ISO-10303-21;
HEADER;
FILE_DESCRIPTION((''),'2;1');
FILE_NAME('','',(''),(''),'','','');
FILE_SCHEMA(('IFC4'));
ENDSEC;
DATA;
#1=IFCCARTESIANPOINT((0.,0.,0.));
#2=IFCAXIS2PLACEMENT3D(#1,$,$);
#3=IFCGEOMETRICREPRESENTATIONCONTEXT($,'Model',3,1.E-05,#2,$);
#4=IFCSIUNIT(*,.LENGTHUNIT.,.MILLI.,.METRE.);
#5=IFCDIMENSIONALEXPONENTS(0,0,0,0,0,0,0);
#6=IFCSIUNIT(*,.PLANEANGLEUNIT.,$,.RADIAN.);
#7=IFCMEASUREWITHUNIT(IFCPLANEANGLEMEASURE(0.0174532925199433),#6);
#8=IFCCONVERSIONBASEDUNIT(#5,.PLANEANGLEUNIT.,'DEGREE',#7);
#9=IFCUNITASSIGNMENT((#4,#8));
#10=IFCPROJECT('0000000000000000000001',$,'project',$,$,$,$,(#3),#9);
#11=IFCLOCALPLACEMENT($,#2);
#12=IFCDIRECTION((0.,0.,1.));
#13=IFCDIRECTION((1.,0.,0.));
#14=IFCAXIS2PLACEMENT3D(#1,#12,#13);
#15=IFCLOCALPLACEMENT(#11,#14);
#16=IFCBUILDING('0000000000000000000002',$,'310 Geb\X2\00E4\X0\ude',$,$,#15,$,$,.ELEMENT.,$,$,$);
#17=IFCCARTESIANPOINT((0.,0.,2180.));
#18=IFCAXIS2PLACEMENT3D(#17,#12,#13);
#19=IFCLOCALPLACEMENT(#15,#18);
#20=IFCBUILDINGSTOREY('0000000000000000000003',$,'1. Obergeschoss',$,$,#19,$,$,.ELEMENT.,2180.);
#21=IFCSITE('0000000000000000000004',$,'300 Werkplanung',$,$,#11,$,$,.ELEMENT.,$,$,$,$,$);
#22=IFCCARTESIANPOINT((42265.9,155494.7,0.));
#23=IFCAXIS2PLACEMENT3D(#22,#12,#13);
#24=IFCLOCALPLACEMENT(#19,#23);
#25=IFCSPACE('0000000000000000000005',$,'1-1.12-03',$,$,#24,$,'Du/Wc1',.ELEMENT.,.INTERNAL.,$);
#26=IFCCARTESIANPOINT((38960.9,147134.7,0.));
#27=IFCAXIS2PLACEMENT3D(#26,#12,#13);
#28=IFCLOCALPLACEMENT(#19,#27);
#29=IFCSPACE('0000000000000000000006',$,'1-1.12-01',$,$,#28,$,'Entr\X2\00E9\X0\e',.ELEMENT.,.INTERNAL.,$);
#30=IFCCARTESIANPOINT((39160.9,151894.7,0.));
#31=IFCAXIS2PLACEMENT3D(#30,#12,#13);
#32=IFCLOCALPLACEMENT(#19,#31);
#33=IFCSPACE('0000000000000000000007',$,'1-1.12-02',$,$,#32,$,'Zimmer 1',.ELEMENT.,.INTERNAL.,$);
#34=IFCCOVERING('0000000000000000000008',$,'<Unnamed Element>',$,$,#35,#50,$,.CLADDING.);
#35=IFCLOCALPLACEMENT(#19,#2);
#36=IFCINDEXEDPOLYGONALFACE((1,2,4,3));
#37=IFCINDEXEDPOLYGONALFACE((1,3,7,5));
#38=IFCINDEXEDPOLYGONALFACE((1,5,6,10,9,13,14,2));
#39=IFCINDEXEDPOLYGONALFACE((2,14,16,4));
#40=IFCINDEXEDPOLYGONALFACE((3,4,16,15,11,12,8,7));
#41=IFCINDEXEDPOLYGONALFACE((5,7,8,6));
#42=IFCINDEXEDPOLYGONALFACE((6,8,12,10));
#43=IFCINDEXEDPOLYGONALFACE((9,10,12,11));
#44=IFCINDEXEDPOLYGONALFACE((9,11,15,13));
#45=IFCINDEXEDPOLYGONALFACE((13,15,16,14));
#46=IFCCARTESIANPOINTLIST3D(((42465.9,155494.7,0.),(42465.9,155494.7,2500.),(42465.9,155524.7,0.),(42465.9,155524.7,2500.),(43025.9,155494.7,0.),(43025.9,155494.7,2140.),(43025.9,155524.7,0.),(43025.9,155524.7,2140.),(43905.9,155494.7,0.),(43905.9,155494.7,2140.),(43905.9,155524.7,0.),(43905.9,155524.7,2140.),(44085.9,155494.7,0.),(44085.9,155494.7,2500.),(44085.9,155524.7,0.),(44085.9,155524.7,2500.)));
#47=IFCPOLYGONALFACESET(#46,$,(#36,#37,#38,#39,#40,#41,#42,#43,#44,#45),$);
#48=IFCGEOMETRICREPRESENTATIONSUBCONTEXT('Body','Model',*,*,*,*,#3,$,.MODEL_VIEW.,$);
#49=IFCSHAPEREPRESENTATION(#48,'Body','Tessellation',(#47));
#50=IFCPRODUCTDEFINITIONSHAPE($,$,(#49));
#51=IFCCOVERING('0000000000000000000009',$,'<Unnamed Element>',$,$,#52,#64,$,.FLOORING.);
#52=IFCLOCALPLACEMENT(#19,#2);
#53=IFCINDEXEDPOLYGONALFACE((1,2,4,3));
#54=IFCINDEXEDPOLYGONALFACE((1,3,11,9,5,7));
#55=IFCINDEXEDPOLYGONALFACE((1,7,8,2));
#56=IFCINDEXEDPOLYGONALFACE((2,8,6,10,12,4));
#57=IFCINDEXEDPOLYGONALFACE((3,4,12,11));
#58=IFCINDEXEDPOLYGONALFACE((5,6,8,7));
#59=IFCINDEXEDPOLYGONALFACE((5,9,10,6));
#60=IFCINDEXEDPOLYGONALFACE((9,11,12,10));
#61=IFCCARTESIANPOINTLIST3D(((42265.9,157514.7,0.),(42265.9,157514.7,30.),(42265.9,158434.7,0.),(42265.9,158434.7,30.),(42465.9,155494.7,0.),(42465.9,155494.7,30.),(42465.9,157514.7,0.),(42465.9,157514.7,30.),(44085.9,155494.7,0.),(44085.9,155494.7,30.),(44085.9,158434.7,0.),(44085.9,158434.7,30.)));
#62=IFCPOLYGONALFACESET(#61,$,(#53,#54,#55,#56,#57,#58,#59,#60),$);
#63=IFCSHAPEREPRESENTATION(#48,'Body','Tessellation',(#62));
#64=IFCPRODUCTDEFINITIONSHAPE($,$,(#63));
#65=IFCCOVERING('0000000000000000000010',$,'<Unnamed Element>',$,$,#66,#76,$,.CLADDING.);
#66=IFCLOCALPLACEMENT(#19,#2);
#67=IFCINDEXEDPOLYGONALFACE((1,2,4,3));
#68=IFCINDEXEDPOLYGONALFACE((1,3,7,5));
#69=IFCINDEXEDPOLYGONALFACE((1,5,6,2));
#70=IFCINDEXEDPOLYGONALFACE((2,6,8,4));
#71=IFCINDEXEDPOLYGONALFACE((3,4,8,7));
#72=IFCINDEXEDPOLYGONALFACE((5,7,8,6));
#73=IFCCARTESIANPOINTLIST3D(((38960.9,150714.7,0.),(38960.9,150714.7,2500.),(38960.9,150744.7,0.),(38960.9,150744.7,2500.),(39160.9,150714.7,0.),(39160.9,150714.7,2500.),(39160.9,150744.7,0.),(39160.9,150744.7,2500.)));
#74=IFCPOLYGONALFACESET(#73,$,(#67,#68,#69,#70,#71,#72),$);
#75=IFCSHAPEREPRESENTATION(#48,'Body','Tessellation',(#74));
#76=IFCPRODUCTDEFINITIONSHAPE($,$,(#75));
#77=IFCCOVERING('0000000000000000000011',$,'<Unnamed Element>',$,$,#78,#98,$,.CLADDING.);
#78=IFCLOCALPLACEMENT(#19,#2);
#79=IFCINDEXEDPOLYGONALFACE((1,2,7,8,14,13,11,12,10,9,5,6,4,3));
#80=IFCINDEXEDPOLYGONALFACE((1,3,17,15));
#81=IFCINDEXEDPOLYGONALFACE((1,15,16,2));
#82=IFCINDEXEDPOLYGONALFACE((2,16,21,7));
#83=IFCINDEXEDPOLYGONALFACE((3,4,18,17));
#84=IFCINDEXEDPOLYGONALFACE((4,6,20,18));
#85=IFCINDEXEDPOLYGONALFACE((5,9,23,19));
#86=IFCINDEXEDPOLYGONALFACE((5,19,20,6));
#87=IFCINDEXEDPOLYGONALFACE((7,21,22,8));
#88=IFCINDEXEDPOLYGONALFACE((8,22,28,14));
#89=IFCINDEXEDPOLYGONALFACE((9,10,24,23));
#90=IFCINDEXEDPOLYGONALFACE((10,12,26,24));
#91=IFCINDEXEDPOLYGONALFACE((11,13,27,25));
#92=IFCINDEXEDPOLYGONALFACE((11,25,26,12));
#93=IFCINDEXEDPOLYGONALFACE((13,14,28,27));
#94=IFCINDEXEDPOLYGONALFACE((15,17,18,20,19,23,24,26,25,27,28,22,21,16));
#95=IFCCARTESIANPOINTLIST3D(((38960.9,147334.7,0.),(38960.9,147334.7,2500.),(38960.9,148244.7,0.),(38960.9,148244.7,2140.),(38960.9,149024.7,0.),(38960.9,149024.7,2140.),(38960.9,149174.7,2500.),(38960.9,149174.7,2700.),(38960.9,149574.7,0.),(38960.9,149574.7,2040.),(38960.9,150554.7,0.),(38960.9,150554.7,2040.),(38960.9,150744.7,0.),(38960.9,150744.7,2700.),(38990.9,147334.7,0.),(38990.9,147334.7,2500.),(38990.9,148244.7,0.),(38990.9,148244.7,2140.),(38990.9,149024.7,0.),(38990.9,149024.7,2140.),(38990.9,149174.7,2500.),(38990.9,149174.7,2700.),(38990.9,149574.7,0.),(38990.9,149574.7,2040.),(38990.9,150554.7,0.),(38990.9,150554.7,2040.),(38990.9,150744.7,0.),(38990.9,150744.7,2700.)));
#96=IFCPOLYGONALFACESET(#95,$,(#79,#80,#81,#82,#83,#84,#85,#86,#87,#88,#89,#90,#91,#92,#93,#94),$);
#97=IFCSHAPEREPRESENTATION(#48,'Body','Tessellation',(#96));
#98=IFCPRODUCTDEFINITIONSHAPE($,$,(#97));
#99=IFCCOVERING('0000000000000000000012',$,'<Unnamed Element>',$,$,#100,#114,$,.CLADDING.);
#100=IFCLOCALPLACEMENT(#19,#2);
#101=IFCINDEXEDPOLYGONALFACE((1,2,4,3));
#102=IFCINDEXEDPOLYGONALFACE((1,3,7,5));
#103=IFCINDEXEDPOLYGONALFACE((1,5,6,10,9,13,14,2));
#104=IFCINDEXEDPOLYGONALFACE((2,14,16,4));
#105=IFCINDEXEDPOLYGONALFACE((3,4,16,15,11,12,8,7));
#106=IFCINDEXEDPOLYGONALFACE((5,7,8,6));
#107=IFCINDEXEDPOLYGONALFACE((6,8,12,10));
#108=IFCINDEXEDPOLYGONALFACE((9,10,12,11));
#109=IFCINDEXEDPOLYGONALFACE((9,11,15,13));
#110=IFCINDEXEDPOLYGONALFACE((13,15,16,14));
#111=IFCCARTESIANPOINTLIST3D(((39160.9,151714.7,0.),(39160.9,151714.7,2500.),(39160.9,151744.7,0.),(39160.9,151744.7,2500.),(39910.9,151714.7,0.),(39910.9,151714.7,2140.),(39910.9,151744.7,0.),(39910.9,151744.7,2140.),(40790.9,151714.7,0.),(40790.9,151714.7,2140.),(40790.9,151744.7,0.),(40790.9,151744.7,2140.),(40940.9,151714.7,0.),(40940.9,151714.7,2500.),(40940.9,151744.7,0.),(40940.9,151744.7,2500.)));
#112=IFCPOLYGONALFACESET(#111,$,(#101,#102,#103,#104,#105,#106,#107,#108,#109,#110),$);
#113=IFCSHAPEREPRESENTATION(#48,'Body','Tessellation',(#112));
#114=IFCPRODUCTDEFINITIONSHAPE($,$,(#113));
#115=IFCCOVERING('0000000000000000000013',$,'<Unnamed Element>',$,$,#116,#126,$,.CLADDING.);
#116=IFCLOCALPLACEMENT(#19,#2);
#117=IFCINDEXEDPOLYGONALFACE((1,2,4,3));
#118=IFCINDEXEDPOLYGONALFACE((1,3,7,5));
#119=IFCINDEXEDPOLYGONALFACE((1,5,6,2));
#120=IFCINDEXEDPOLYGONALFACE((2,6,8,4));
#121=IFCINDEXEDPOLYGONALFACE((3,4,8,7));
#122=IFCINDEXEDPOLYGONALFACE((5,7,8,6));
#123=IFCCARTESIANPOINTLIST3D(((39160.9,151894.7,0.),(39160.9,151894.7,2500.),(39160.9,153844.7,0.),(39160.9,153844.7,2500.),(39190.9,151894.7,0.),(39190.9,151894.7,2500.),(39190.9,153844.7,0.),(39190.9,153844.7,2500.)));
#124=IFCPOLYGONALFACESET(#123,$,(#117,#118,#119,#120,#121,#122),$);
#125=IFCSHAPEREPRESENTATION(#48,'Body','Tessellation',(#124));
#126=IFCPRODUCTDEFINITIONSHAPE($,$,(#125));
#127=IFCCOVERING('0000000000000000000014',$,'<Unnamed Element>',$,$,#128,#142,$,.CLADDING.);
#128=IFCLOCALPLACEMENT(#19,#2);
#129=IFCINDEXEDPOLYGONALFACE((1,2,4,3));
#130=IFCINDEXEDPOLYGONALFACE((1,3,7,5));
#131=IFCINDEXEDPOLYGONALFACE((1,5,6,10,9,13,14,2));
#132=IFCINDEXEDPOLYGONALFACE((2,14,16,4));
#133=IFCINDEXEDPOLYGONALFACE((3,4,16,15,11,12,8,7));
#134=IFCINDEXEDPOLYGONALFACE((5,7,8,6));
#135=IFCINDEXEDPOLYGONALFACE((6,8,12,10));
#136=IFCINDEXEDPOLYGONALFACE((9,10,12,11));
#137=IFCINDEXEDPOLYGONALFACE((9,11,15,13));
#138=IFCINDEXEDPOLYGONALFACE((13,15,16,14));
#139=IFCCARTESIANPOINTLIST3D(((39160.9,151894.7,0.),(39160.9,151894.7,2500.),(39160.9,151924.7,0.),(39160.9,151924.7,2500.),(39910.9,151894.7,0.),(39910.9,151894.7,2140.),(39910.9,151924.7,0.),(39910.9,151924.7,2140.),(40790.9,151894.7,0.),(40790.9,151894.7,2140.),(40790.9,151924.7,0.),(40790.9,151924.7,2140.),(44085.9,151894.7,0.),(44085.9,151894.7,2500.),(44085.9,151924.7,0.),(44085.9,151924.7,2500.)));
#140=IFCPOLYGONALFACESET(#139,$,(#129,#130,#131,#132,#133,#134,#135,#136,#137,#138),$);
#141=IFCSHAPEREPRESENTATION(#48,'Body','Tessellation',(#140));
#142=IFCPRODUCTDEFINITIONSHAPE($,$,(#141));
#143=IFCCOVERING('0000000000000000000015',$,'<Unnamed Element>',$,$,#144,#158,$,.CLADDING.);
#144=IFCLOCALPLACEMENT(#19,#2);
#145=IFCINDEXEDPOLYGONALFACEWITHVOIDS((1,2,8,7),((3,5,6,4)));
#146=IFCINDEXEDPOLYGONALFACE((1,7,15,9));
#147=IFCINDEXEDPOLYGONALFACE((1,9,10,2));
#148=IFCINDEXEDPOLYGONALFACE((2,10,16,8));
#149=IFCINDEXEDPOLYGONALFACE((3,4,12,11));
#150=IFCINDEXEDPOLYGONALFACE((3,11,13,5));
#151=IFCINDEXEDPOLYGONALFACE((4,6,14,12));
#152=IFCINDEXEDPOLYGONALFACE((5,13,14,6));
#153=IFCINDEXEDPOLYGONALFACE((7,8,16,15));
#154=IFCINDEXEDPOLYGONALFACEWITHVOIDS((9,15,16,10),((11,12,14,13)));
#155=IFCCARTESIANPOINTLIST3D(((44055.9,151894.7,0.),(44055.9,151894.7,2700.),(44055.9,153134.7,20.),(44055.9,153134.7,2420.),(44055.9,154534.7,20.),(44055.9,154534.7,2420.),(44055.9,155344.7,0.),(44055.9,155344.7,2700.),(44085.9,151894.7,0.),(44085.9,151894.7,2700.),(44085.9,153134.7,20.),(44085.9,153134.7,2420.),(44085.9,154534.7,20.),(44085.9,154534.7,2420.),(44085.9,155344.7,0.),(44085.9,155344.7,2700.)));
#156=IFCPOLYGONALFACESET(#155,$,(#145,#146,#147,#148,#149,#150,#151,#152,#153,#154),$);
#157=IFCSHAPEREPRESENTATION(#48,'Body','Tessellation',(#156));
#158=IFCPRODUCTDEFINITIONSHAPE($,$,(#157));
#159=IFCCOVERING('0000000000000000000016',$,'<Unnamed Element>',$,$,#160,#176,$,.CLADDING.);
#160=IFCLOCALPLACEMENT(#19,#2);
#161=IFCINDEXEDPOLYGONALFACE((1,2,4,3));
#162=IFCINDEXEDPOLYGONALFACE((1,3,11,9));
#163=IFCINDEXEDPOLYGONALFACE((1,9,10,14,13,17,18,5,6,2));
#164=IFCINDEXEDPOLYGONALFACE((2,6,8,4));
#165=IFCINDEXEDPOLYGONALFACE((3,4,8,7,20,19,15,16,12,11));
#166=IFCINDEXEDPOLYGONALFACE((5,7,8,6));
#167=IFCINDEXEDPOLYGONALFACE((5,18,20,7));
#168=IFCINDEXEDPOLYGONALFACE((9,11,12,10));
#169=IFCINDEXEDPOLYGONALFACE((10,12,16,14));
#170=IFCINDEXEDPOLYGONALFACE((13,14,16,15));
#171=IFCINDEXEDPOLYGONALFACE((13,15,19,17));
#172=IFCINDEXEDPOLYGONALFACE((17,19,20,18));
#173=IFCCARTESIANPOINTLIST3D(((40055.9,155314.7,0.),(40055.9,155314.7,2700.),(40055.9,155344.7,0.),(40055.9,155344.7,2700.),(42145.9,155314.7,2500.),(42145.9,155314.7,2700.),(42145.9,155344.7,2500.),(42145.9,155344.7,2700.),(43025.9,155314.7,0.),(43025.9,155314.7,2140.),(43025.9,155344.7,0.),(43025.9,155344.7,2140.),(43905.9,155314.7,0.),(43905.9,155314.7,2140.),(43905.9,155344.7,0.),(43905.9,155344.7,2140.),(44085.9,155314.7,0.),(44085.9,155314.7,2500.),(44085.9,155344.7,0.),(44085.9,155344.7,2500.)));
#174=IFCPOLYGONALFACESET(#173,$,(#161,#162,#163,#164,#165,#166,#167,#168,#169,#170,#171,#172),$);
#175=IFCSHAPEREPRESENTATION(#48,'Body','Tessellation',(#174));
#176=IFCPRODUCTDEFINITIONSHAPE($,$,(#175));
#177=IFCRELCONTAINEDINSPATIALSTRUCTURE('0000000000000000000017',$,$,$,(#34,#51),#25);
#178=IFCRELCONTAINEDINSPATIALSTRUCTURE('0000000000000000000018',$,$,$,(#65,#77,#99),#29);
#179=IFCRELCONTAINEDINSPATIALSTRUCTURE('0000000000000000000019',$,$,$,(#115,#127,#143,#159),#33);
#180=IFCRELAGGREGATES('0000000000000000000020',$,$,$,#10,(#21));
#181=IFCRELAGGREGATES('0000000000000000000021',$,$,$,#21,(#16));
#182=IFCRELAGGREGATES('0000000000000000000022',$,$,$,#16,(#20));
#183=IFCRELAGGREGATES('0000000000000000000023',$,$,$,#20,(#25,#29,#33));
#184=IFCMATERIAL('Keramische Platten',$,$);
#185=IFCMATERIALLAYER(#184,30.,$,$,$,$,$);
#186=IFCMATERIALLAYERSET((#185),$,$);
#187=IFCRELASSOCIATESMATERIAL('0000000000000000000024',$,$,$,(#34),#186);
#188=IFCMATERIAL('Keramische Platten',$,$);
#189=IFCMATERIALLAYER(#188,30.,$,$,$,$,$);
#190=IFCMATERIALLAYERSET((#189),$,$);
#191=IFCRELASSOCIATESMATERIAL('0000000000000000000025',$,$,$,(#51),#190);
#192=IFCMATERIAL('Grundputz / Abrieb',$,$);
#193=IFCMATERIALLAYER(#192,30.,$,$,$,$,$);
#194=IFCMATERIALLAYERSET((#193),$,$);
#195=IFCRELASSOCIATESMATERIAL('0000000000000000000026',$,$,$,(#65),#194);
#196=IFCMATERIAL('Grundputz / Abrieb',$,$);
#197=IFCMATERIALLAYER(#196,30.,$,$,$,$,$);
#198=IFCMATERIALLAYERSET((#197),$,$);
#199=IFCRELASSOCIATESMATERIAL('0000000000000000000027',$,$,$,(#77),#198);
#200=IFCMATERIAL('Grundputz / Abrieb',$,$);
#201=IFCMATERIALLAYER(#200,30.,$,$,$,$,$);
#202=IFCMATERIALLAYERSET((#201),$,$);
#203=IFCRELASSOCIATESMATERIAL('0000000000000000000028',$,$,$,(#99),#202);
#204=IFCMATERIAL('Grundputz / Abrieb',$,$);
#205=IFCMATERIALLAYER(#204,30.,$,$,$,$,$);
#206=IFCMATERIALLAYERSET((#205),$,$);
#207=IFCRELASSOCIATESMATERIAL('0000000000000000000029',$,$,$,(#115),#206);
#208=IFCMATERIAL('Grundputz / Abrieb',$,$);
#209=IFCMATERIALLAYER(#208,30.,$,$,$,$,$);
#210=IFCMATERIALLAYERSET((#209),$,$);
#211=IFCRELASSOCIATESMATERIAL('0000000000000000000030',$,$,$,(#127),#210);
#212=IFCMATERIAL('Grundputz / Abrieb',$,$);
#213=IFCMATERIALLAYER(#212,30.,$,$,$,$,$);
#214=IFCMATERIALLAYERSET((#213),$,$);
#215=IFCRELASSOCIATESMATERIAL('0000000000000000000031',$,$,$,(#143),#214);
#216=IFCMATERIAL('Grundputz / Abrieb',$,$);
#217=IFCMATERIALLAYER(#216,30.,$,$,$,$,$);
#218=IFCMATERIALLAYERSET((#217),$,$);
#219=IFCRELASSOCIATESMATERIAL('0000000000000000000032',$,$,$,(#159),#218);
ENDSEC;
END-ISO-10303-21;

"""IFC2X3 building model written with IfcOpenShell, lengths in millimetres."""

from ifc_helpers import new_model, entity, si_unit, converted_unit, frame, frame_2d, origin, origin_with_axes, place, context, subcontext, project, spatial, polyline, rectangle, outline, extrude, material, layer, layer_set, layer_usage, element, save


model = new_model("IFC2X3")

# Units and contexts
model_context = context("Model", 3, precision=1e-05, world=origin())
body_context = subcontext(model_context, "Body", "Model", "MODEL_VIEW")
ifc_project = project(units=[si_unit("LENGTHUNIT", "METRE", prefix="MILLI"), converted_unit("PLANEANGLEUNIT", "DEGREE", entity("IfcPlaneAngleMeasure", 0.0174532925199433), si_unit("PLANEANGLEUNIT", "RADIAN"), dimensions=[0, 0, 0, 0, 0, 0, 0])], contexts=[model_context])

# Site, building, storey
site_placement = place(None, origin())
site = spatial("IfcSite", under=ifc_project, at=site_placement, Name="300 Werkplanung", CompositionType="ELEMENT")
building_placement = place(site_placement, origin_with_axes())
building = spatial("IfcBuilding", under=site, at=building_placement, Name="310 Gebäude", CompositionType="ELEMENT")
storey_placement = place(building_placement, frame((0.0, 0.0, 2180.0), z_axis=(0.0, 0.0, 1.0), x_axis=(1.0, 0.0, 0.0)))
storey = spatial("IfcBuildingStorey", under=building, at=storey_placement, Name="1. Obergeschoss", CompositionType="ELEMENT", Elevation=2180.0)

# Shared definitions
space_1_placement = place(storey_placement, frame((42265.9, 155494.7, 0.0), z_axis=(0.0, 0.0, 1.0), x_axis=(1.0, 0.0, 0.0)))
space_1 = spatial("IfcSpace", under=storey, at=space_1_placement, Name="1-1.12-03", LongName="Du/Wc1", CompositionType="ELEMENT", InteriorOrExteriorSpace="INTERNAL")

# Coverings
ifc_material_1 = material(Name="Keramische Platten")
ifc_layer_1 = layer(ifc_material_1, 30.0)
ifc_layer_set_1 = layer_set([ifc_layer_1])
ifc_layer_usage_1 = layer_usage(ifc_layer_set_1, "AXIS3", "POSITIVE", 0.0)
covering_1_placement = place(space_1_placement, frame((200.0, 0.0, 0.0), z_axis=(0.0, 0.0, 1.0), x_axis=(1.0, 0.0, 0.0)))
element("IfcCovering", 1, at=covering_1_placement, inside=space_1, material=ifc_layer_usage_1, Name="<Unnamed Element>", PredefinedType="CLADDING", context=body_context, shape_type="SweptSolid", body=[
    extrude(outline(polyline([(1620.0, 0.0), (1620.0, -2500.0), (0.0, -2500.0), (0.0, 0.0), (560.0, 0.0), (560.0, -2140.0), (1440.0, -2140.0), (1440.0, 0.0), (1620.0, 0.0)])), frame((0.0, 0.0, 0.0), z_axis=(0.0, 1.0, 0.0), x_axis=(1.0, 0.0, 0.0)), (0.0, 0.0, 1.0), 30.0),
])
ifc_material_2 = material(Name="Keramische Platten")
ifc_layer_2 = layer(ifc_material_2, 30.0)
ifc_layer_set_2 = layer_set([ifc_layer_2])
ifc_layer_usage_2 = layer_usage(ifc_layer_set_2, "AXIS3", "POSITIVE", 0.0)
covering_2_placement = place(space_1_placement, origin_with_axes())
element("IfcCovering", 2, at=covering_2_placement, inside=space_1, material=ifc_layer_usage_2, Name="<Unnamed Element>", PredefinedType="FLOORING", context=body_context, shape_type="SweptSolid", body=[
    extrude(outline(polyline([(1820.0, 2940.0), (0.0, 2940.0), (0.0, 2020.0), (200.0, 2020.0), (200.0, 0.0), (1820.0, 0.0), (1820.0, 2940.0)])), origin_with_axes(), (0.0, 0.0, 1.0), 30.0),
])

# Shared definitions
space_2_placement = place(storey_placement, frame((38960.9, 147134.7, 0.0), z_axis=(0.0, 0.0, 1.0), x_axis=(1.0, 0.0, 0.0)))
space_2 = spatial("IfcSpace", under=storey, at=space_2_placement, Name="1-1.12-01", LongName="Entrée", CompositionType="ELEMENT", InteriorOrExteriorSpace="INTERNAL")

# Coverings
ifc_material_3 = material(Name="Grundputz / Abrieb")
ifc_layer_3 = layer(ifc_material_3, 30.0)
ifc_layer_set_3 = layer_set([ifc_layer_3])
ifc_layer_usage_3 = layer_usage(ifc_layer_set_3, "AXIS3", "POSITIVE", 0.0)
covering_3_placement = place(space_2_placement, frame((200.0, 3610.0, 0.0), z_axis=(0.0, 0.0, 1.0), x_axis=(-1.0, 0.0, 0.0)))
element("IfcCovering", 3, at=covering_3_placement, inside=space_2, material=ifc_layer_usage_3, Name="<Unnamed Element>", PredefinedType="CLADDING", context=body_context, shape_type="SweptSolid", body=[
    extrude(rectangle(XDim=2500.0, YDim=200.0, at=frame_2d((-100.0, 1250.0), x_axis=(0.0, 1.0))), frame((200.0, 0.0, 2500.0), z_axis=(0.0, 1.0, 0.0), x_axis=(1.0, 0.0, 0.0)), (0.0, 0.0, 1.0), 30.0),
])
ifc_material_4 = material(Name="Grundputz / Abrieb")
ifc_layer_4 = layer(ifc_material_4, 30.0)
ifc_layer_set_4 = layer_set([ifc_layer_4])
ifc_layer_usage_4 = layer_usage(ifc_layer_set_4, "AXIS3", "POSITIVE", 0.0)
covering_4_placement = place(space_2_placement, frame((0.0, 3610.0, 0.0), z_axis=(0.0, 0.0, 1.0), x_axis=(0.0, -1.0, 0.0)))
element("IfcCovering", 4, at=covering_4_placement, inside=space_2, material=ifc_layer_usage_4, Name="<Unnamed Element>", PredefinedType="CLADDING", context=body_context, shape_type="SweptSolid", body=[
    extrude(outline(polyline([(3410.0, 0.0), (3410.0, -2500.0), (1570.0, -2500.0), (1570.0, -2700.0), (0.0, -2700.0), (0.0, 0.0), (190.0, 0.0), (190.0, -2040.0), (1170.0, -2040.0), (1170.0, 0.0), (1720.0, 0.0), (1720.0, -2140.0), (2500.0, -2140.0), (2500.0, 0.0), (3410.0, 0.0)])), frame((0.0, 0.0, 0.0), z_axis=(0.0, 1.0, 0.0), x_axis=(1.0, 0.0, 0.0)), (0.0, 0.0, 1.0), 30.0),
])
ifc_material_5 = material(Name="Grundputz / Abrieb")
ifc_layer_5 = layer(ifc_material_5, 30.0)
ifc_layer_set_5 = layer_set([ifc_layer_5])
ifc_layer_usage_5 = layer_usage(ifc_layer_set_5, "AXIS3", "POSITIVE", 0.0)
covering_5_placement = place(space_2_placement, frame((1980.0, 4610.0, 0.0), z_axis=(0.0, 0.0, 1.0), x_axis=(-1.0, 0.0, 0.0)))
element("IfcCovering", 5, at=covering_5_placement, inside=space_2, material=ifc_layer_usage_5, Name="<Unnamed Element>", PredefinedType="CLADDING", context=body_context, shape_type="SweptSolid", body=[
    extrude(outline(polyline([(1780.0, 0.0), (1780.0, -2500.0), (0.0, -2500.0), (0.0, 0.0), (150.0, 0.0), (150.0, -2140.0), (1030.0, -2140.0), (1030.0, 0.0), (1780.0, 0.0)])), frame((0.0, 0.0, 0.0), z_axis=(0.0, 1.0, 0.0), x_axis=(1.0, 0.0, 0.0)), (0.0, 0.0, 1.0), 30.0),
])

# Shared definitions
space_3_placement = place(storey_placement, frame((39160.9, 151894.7, 0.0), z_axis=(0.0, 0.0, 1.0), x_axis=(1.0, 0.0, 0.0)))
space_3 = spatial("IfcSpace", under=storey, at=space_3_placement, Name="1-1.12-02", LongName="Zimmer 1", CompositionType="ELEMENT", InteriorOrExteriorSpace="INTERNAL")

# Coverings
ifc_material_6 = material(Name="Grundputz / Abrieb")
ifc_layer_6 = layer(ifc_material_6, 30.0)
ifc_layer_set_6 = layer_set([ifc_layer_6])
ifc_layer_usage_6 = layer_usage(ifc_layer_set_6, "AXIS3", "POSITIVE", 0.0)
covering_6_placement = place(space_3_placement, frame((0.0, 1950.0, 0.0), z_axis=(0.0, 0.0, 1.0), x_axis=(0.0, -1.0, 0.0)))
element("IfcCovering", 6, at=covering_6_placement, inside=space_3, material=ifc_layer_usage_6, Name="<Unnamed Element>", PredefinedType="CLADDING", context=body_context, shape_type="SweptSolid", body=[
    extrude(rectangle(XDim=2500.0, YDim=1950.0, at=frame_2d((-975.0, 1250.0), x_axis=(0.0, 1.0))), frame((1950.0, 0.0, 2500.0), z_axis=(0.0, 1.0, 0.0), x_axis=(1.0, 0.0, 0.0)), (0.0, 0.0, 1.0), 30.0),
])
ifc_material_7 = material(Name="Grundputz / Abrieb")
ifc_layer_7 = layer(ifc_material_7, 30.0)
ifc_layer_set_7 = layer_set([ifc_layer_7])
ifc_layer_usage_7 = layer_usage(ifc_layer_set_7, "AXIS3", "POSITIVE", 0.0)
covering_7_placement = place(space_3_placement, frame((0.0, 0.0, 0.0), z_axis=(0.0, 0.0, 1.0), x_axis=(1.0, 0.0, 0.0)))
element("IfcCovering", 7, at=covering_7_placement, inside=space_3, material=ifc_layer_usage_7, Name="<Unnamed Element>", PredefinedType="CLADDING", context=body_context, shape_type="SweptSolid", body=[
    extrude(outline(polyline([(4925.0, 0.0), (4925.0, -2500.0), (0.0, -2500.0), (0.0, 0.0), (750.0, 0.0), (750.0, -2140.0), (1630.0, -2140.0), (1630.0, 0.0), (4925.0, 0.0)])), frame((0.0, 0.0, 0.0), z_axis=(0.0, 1.0, 0.0), x_axis=(1.0, 0.0, 0.0)), (0.0, 0.0, 1.0), 30.0),
])
ifc_material_8 = material(Name="Grundputz / Abrieb")
ifc_layer_8 = layer(ifc_material_8, 30.0)
ifc_layer_set_8 = layer_set([ifc_layer_8])
ifc_layer_usage_8 = layer_usage(ifc_layer_set_8, "AXIS3", "POSITIVE", 0.0)
covering_8_placement = place(space_3_placement, frame((4925.0, 0.0, 0.0), z_axis=(0.0, 0.0, 1.0), x_axis=(0.0, 1.0, 0.0)))
element("IfcCovering", 8, at=covering_8_placement, inside=space_3, material=ifc_layer_usage_8, Name="<Unnamed Element>", PredefinedType="CLADDING", context=body_context, shape_type="SweptSolid", body=[
    extrude(outline(polyline([(3450.0, 0.0), (3450.0, -2700.0), (0.0, -2700.0), (0.0, 0.0), (3450.0, 0.0)]), holes=[polyline([(2640.0, -20.0), (1240.0, -20.0), (1240.0, -2420.0), (2640.0, -2420.0), (2640.0, -20.0)])]), frame((0.0, 0.0, 0.0), z_axis=(0.0, 1.0, 0.0), x_axis=(1.0, 0.0, 0.0)), (0.0, 0.0, 1.0), 30.0),
])
ifc_material_9 = material(Name="Grundputz / Abrieb")
ifc_layer_9 = layer(ifc_material_9, 30.0)
ifc_layer_set_9 = layer_set([ifc_layer_9])
ifc_layer_usage_9 = layer_usage(ifc_layer_set_9, "AXIS3", "POSITIVE", 0.0)
covering_9_placement = place(space_3_placement, frame((4925.0, 3450.0, 0.0), z_axis=(0.0, 0.0, 1.0), x_axis=(-1.0, 0.0, 0.0)))
element("IfcCovering", 9, at=covering_9_placement, inside=space_3, material=ifc_layer_usage_9, Name="<Unnamed Element>", PredefinedType="CLADDING", context=body_context, shape_type="SweptSolid", body=[
    extrude(outline(polyline([(0.0, -2500.0), (0.0, 0.0), (180.0, 0.0), (180.0, -2140.0), (1060.0, -2140.0), (1060.0, 0.0), (4030.0, 0.0), (4030.0, -2700.0), (1940.0, -2700.0), (1940.0, -2500.0), (0.0, -2500.0)])), frame((0.0, 0.0, 0.0), z_axis=(0.0, 1.0, 0.0), x_axis=(1.0, 0.0, 0.0)), (0.0, 0.0, 1.0), 30.0),
])

save(model, "model.ifc")
